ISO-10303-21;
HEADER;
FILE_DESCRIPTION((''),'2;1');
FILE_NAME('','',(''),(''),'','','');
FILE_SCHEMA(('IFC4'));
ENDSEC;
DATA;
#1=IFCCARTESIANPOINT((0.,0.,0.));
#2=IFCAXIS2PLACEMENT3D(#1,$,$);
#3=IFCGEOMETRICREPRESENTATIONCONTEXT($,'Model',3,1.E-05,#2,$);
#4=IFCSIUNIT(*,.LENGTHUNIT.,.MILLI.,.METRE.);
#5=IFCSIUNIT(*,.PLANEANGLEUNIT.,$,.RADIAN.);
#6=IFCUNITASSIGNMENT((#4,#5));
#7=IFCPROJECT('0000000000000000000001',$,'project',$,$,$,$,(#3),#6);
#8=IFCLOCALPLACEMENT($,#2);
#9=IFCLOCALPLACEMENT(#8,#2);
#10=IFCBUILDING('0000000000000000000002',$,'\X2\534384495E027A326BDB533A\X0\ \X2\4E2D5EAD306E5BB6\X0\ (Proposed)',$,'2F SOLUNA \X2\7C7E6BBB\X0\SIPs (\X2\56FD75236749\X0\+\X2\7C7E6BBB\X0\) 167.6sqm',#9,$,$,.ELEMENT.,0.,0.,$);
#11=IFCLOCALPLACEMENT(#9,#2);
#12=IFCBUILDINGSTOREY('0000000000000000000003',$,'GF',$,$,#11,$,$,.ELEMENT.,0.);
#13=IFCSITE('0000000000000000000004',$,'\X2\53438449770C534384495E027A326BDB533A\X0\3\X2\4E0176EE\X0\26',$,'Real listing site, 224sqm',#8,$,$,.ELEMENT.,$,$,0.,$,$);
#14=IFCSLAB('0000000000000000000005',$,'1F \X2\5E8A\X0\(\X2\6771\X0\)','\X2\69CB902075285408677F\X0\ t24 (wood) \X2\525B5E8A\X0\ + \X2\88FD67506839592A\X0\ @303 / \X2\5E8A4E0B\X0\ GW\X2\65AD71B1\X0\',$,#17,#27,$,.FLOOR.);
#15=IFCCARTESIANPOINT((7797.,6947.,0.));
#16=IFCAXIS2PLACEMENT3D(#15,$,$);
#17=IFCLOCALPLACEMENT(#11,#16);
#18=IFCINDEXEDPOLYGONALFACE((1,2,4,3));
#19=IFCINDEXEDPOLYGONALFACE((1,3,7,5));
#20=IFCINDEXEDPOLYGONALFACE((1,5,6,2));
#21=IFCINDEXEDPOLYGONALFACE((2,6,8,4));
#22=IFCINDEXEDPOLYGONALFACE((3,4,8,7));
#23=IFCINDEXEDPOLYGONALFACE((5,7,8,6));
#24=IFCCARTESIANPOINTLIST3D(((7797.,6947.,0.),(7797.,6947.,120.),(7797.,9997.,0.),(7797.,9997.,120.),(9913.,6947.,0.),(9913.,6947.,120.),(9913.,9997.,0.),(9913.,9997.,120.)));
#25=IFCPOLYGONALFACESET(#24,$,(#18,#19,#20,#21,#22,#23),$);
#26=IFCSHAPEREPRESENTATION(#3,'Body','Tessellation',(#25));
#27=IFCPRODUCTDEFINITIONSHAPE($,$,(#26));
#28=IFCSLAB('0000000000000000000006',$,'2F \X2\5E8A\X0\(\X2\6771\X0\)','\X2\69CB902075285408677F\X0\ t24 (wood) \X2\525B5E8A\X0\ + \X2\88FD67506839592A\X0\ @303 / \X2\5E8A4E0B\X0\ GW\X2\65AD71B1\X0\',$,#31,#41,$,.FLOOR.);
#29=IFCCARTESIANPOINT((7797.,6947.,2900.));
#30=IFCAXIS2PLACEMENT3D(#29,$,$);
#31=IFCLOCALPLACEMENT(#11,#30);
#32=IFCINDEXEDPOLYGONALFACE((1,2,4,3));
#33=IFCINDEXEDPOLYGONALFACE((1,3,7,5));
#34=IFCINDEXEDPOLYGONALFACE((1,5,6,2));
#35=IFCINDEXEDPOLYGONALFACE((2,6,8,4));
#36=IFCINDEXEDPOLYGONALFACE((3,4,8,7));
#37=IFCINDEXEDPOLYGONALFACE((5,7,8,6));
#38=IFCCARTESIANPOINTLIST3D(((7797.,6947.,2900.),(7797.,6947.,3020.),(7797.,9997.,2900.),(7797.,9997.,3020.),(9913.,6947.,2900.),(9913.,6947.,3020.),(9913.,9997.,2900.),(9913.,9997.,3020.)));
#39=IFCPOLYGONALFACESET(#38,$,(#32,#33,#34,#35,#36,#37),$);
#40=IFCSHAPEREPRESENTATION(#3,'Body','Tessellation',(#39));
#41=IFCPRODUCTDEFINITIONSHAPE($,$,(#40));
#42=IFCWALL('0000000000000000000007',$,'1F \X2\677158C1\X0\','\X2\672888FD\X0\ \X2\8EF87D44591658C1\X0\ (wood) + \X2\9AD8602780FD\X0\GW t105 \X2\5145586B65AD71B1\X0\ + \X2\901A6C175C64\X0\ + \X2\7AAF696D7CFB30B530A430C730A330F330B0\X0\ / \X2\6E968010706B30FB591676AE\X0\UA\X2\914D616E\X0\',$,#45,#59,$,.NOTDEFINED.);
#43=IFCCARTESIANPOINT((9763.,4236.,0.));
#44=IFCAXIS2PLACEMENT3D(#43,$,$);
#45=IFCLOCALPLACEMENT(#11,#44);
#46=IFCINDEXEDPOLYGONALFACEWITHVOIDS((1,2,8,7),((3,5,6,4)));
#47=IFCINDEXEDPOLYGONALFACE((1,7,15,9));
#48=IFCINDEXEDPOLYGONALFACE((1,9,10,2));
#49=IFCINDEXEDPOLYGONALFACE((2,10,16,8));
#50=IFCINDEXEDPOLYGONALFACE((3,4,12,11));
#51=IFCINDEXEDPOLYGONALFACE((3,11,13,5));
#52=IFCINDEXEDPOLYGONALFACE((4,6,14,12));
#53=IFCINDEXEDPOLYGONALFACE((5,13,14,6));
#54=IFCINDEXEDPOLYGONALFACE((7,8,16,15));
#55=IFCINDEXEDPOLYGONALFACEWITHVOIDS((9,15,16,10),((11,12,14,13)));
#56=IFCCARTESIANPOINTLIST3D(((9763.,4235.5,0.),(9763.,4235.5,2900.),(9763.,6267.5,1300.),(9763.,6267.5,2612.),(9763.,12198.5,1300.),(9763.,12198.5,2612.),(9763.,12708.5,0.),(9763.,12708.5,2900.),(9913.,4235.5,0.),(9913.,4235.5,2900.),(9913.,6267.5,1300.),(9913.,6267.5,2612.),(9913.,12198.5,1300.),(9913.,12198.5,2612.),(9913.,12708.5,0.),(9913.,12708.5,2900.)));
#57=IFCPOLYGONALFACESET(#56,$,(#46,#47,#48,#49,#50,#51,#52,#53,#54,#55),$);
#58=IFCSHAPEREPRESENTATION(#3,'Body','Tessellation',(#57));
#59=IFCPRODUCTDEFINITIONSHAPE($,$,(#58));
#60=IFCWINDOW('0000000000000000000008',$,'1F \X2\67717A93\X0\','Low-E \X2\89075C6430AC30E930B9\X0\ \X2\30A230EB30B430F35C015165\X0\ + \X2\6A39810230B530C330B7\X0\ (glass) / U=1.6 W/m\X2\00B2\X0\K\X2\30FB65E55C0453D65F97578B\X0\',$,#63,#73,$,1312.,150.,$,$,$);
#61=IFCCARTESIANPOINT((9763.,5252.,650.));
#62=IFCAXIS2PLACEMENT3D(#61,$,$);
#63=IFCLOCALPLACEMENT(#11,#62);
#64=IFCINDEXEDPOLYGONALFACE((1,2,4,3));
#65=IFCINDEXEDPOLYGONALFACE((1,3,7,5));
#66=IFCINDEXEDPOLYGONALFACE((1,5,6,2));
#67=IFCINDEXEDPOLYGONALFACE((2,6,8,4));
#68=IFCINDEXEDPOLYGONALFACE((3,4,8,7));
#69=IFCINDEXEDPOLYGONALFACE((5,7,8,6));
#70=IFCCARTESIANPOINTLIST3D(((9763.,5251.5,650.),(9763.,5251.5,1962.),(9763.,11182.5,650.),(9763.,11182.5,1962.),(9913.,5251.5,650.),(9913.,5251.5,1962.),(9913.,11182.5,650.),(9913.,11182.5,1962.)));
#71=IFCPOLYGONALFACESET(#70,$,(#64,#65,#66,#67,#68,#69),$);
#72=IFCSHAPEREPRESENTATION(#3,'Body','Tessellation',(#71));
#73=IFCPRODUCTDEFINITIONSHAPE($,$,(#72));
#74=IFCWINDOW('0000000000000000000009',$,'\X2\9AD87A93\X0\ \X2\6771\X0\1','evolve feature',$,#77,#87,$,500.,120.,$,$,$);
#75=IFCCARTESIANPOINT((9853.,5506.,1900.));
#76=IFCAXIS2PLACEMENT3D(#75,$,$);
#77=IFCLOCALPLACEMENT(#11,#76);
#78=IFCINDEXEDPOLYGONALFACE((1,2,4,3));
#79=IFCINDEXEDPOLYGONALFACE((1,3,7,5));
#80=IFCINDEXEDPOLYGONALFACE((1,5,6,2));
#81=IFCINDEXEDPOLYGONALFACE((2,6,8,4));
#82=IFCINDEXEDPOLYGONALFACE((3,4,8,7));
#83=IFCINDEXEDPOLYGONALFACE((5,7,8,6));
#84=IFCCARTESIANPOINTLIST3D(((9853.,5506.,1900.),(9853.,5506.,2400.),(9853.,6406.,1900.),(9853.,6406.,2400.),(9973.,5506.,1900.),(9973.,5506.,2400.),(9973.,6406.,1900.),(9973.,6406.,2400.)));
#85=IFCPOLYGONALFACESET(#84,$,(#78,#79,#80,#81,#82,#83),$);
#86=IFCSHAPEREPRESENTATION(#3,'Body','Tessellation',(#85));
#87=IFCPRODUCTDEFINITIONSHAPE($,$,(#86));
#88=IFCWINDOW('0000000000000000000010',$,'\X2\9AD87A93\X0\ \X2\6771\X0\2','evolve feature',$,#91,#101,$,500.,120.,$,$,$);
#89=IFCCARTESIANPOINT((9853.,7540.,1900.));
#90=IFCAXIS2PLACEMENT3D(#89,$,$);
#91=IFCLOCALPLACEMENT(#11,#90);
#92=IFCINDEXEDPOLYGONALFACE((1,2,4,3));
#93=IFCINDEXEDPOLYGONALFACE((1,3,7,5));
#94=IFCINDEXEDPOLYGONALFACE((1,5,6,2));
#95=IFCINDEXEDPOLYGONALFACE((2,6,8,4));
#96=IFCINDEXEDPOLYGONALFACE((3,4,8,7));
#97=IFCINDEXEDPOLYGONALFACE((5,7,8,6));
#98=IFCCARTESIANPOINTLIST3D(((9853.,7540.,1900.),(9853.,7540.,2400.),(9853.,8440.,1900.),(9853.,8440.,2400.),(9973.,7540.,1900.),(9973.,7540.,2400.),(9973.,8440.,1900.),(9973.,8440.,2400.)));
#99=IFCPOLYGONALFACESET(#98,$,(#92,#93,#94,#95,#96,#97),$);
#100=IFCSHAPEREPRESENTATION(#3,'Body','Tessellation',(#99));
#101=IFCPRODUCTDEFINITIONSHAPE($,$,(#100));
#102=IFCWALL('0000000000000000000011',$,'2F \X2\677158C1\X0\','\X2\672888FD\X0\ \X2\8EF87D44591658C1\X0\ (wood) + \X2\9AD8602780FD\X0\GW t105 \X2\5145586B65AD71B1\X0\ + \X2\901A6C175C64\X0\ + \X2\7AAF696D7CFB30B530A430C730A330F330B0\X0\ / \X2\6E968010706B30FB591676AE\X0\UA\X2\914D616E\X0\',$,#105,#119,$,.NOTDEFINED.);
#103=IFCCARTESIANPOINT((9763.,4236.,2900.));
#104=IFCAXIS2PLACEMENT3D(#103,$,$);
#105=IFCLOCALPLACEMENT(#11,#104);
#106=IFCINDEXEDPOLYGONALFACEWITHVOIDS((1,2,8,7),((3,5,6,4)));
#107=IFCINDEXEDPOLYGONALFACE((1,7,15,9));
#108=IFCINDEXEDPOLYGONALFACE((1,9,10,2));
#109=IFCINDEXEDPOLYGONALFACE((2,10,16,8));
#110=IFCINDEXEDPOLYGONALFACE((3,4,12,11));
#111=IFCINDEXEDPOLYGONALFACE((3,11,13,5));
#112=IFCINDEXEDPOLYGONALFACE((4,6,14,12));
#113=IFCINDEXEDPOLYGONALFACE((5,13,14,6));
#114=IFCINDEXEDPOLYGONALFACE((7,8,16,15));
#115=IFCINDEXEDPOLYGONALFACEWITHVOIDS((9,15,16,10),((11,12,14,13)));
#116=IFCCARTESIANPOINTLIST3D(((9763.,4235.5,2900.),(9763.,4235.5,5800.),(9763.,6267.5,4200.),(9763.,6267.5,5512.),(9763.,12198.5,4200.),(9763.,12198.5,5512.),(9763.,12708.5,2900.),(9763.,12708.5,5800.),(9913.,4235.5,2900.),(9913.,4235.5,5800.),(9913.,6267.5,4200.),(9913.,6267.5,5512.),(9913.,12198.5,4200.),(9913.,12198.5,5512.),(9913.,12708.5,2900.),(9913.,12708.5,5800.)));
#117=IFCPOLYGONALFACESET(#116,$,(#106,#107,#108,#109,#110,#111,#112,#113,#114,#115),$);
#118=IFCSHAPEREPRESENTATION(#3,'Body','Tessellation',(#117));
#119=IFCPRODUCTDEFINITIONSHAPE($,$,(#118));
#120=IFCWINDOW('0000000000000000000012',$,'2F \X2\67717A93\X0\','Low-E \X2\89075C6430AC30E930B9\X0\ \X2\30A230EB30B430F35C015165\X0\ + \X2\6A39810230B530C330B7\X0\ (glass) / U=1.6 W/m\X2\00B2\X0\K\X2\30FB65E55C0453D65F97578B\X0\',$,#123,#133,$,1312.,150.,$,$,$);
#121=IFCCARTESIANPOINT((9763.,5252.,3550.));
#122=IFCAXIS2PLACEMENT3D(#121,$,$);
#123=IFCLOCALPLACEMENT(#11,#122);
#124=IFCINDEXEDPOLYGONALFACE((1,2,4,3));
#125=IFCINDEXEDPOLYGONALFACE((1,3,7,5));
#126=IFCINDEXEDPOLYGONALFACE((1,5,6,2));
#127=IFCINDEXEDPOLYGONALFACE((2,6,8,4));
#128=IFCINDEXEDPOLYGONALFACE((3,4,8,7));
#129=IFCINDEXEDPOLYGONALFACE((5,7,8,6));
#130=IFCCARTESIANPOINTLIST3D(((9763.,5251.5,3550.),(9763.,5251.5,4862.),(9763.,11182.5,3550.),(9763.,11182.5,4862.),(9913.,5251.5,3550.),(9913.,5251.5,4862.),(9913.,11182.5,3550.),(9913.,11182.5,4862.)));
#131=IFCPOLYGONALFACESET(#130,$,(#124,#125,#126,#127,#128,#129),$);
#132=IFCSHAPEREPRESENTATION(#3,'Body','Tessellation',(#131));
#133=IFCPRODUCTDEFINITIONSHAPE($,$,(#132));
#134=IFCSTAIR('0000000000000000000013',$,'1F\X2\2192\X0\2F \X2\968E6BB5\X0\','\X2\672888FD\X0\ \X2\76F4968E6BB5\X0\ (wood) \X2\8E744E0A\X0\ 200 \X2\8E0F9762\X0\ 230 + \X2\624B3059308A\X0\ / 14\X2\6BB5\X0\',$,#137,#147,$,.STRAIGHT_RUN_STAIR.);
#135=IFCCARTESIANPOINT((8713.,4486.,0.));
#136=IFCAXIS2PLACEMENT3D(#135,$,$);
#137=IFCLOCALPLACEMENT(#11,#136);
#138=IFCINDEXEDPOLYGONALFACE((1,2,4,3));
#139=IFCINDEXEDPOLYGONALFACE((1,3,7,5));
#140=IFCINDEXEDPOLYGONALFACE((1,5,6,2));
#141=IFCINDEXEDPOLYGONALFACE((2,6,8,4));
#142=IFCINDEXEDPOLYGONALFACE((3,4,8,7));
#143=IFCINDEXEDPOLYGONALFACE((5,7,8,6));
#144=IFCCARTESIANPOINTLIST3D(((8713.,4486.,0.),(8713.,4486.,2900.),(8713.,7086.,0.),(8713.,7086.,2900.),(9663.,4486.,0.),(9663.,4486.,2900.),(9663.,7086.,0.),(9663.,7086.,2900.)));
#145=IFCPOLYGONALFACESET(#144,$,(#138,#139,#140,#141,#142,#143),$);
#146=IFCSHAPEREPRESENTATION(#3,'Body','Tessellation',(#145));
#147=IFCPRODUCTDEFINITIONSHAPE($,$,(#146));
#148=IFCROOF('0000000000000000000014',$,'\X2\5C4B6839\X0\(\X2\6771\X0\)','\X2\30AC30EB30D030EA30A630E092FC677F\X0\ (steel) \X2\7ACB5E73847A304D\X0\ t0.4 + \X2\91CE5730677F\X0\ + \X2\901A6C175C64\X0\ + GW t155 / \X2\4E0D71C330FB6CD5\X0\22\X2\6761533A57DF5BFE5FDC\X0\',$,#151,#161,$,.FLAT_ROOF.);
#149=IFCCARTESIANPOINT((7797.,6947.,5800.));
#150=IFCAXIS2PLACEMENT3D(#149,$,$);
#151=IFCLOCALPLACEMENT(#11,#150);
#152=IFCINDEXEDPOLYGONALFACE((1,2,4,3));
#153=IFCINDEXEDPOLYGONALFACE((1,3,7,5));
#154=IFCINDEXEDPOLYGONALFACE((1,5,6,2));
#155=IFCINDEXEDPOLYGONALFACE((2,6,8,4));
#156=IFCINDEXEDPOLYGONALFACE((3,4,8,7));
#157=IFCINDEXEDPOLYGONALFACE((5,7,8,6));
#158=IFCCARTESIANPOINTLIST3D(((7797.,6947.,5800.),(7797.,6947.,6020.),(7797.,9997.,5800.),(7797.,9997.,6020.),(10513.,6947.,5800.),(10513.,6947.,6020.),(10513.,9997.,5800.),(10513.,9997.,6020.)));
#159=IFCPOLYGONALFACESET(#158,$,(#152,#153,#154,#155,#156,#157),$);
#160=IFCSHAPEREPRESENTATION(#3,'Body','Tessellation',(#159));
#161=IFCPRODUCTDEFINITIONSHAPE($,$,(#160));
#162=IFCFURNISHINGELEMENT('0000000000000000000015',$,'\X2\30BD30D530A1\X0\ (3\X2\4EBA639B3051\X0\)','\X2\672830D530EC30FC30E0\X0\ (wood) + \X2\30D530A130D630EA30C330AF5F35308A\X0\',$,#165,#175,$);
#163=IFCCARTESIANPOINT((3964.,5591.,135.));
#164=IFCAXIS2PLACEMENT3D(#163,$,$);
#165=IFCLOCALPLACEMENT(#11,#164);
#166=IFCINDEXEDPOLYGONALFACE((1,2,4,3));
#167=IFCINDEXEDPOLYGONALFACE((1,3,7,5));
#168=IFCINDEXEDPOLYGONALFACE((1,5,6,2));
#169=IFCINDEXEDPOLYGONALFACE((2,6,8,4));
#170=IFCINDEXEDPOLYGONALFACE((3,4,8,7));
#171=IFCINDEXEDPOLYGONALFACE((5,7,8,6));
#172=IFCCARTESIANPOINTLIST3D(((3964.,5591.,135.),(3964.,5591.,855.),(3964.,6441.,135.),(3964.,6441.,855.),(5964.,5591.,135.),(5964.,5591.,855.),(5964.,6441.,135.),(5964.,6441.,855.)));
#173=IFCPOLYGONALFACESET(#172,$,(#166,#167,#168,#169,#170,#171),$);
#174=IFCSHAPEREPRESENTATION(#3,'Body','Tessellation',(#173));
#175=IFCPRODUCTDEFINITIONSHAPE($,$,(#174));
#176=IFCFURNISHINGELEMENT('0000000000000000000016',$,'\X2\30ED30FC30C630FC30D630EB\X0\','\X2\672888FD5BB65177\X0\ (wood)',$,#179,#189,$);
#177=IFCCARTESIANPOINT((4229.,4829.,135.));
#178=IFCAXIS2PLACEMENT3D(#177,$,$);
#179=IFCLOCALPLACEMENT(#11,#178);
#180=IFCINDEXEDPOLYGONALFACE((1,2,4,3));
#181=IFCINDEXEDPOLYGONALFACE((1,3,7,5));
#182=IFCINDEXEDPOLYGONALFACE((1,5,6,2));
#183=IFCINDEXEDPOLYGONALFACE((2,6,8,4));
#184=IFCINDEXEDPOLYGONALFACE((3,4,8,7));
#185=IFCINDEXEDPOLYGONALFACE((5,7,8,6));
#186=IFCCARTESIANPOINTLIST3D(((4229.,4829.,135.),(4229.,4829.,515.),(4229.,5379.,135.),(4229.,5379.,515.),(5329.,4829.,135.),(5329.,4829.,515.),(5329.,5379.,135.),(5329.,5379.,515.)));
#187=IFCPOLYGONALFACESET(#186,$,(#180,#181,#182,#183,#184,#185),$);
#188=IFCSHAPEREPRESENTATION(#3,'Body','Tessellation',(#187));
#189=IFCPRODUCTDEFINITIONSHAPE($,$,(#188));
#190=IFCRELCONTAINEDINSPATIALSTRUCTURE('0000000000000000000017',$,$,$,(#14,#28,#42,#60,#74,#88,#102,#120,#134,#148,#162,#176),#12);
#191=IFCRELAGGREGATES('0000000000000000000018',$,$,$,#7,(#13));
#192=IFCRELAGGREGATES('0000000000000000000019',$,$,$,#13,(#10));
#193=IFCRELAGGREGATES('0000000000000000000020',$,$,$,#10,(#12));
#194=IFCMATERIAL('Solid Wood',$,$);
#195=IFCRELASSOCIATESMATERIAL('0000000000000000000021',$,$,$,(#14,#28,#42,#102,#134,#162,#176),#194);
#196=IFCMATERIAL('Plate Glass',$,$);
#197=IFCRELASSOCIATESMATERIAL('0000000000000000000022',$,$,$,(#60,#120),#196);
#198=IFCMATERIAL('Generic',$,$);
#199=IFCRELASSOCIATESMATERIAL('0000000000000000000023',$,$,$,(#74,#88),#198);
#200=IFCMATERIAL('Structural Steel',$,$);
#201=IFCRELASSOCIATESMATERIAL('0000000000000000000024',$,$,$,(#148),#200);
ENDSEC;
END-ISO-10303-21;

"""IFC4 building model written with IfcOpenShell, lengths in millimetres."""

from ifc_helpers import new_model, si_unit, frame, frame_2d, origin, place, context, project, spatial, rectangle, extrude, material, element, fill, save


model = new_model("IFC4")

# Units and contexts
model_context = context("Model", 3, precision=1e-05, world=origin())
ifc_project = project(units=[si_unit("LENGTHUNIT", "METRE", prefix="MILLI"), si_unit("PLANEANGLEUNIT", "RADIAN")], contexts=[model_context])

# Site, building, storey
site_placement = place(None, origin())
site = spatial("IfcSite", under=ifc_project, at=site_placement, Name="千葉県千葉市稲毛区3丁目26", ObjectType="Real listing site, 224sqm", CompositionType="ELEMENT", RefElevation=0.0)
building_placement = place(site_placement, origin())
building = spatial("IfcBuilding", under=site, at=building_placement, Name="千葉市稲毛区 中庭の家 (Proposed)", ObjectType="2F SOLUNA 籾殻SIPs (国産杉+籾殻) 167.6sqm", CompositionType="ELEMENT", ElevationOfRefHeight=0.0, ElevationOfTerrain=0.0)
storey_placement = place(building_placement, origin())
storey = spatial("IfcBuildingStorey", under=building, at=storey_placement, Name="GF", CompositionType="ELEMENT", Elevation=0.0)

# Slabs
ifc_material_1 = material(Name="Solid Wood")
slab_1_placement = place(storey_placement, frame((7797.0, 6947.0, 0.0)))
element("IfcSlab", 1, at=slab_1_placement, inside=storey, material=ifc_material_1, Name="1F 床(東)", Description="構造用合板 t24 (wood) 剛床 + 製材根太 @303 / 床下 GW断熱", PredefinedType="FLOOR", context=model_context, shape_type="SweptSolid", body=[
    extrude(rectangle(XDim=2116.0, YDim=3050.0, at=frame_2d((1058.0, 1525.0))), frame((7797.0, 6947.0, 0.0)), (0.0, 0.0, 1.0), 120.0),
])
slab_2_placement = place(storey_placement, frame((7797.0, 6947.0, 2900.0)))
element("IfcSlab", 2, at=slab_2_placement, inside=storey, material=ifc_material_1, Name="2F 床(東)", Description="構造用合板 t24 (wood) 剛床 + 製材根太 @303 / 床下 GW断熱", PredefinedType="FLOOR", context=model_context, shape_type="SweptSolid", body=[
    extrude(rectangle(XDim=2116.0, YDim=3050.0, at=frame_2d((1058.0, 1525.0))), frame((7797.0, 6947.0, 2900.0)), (0.0, 0.0, 1.0), 120.0),
])

# Wall, openings, windows
wall_1_placement = place(storey_placement, frame((9763.0, 4236.0, 0.0)))
wall_1 = element("IfcWall", 3, at=wall_1_placement, inside=storey, material=ifc_material_1, Name="1F 東壁", Description="木製 軸組外壁 (wood) + 高性能GW t105 充填断熱 + 通気層 + 窯業系サイディング / 準耐火・外皮UA配慮", PredefinedType="NOTDEFINED", context=model_context, shape_type="SweptSolid", body=[
    extrude(rectangle(XDim=150.0, YDim=8473.0, at=frame_2d((75.0, 4236.0))), frame((9763.0, 4236.0, 0.0)), (0.0, 0.0, 1.0), 2900.0),
])
opening_1_placement = place(storey_placement, frame((9763.0, 5252.0, 650.0)))
opening_1 = element("IfcOpeningElement", 4, at=opening_1_placement, cuts=wall_1, PredefinedType="NOTDEFINED", context=model_context, shape_type="SweptSolid", body=[
    extrude(rectangle(XDim=150.0, YDim=5931.0, at=frame_2d((75.0, 2965.0))), frame((9763.0, 5252.0, 650.0)), (0.0, 0.0, 1.0), 1312.0),
])
opening_2_placement = place(storey_placement, frame((9853.0, 5506.0, 1900.0)))
opening_2 = element("IfcOpeningElement", 5, at=opening_2_placement, cuts=wall_1, PredefinedType="NOTDEFINED", context=model_context, shape_type="SweptSolid", body=[
    extrude(rectangle(XDim=120.0, YDim=900.0, at=frame_2d((60.0, 450.0))), frame((9853.0, 5506.0, 1900.0)), (0.0, 0.0, 1.0), 500.0),
])
opening_3_placement = place(storey_placement, frame((9853.0, 7540.0, 1900.0)))
opening_3 = element("IfcOpeningElement", 6, at=opening_3_placement, cuts=wall_1, PredefinedType="NOTDEFINED", context=model_context, shape_type="SweptSolid", body=[
    extrude(rectangle(XDim=120.0, YDim=900.0, at=frame_2d((60.0, 450.0))), frame((9853.0, 7540.0, 1900.0)), (0.0, 0.0, 1.0), 500.0),
])
ifc_material_2 = material(Name="Plate Glass")
window_1_placement = place(storey_placement, frame((9763.0, 5252.0, 650.0)))
window_1 = element("IfcWindow", 7, at=window_1_placement, inside=storey, material=ifc_material_2, Name="1F 東窓", Description="Low-E 複層ガラス アルゴン封入 + 樹脂サッシ (glass) / U=1.6 W/m²K・日射取得型", OverallHeight=1312.0, OverallWidth=150.0, context=model_context, shape_type="SweptSolid", body=[
    extrude(rectangle(XDim=150.0, YDim=5931.0, at=frame_2d((75.0, 2965.0))), frame((9763.0, 5252.0, 650.0)), (0.0, 0.0, 1.0), 1312.0),
])
fill(opening_1, window_1)
ifc_material_3 = material(Name="Generic")
window_2_placement = place(storey_placement, frame((9853.0, 5506.0, 1900.0)))
window_2 = element("IfcWindow", 8, at=window_2_placement, inside=storey, material=ifc_material_3, Name="高窓 東1", Description="evolve feature", OverallHeight=500.0, OverallWidth=120.0, context=model_context, shape_type="SweptSolid", body=[
    extrude(rectangle(XDim=120.0, YDim=900.0, at=frame_2d((60.0, 450.0))), frame((9853.0, 5506.0, 1900.0)), (0.0, 0.0, 1.0), 500.0),
])
fill(opening_2, window_2)
window_3_placement = place(storey_placement, frame((9853.0, 7540.0, 1900.0)))
window_3 = element("IfcWindow", 9, at=window_3_placement, inside=storey, material=ifc_material_3, Name="高窓 東2", Description="evolve feature", OverallHeight=500.0, OverallWidth=120.0, context=model_context, shape_type="SweptSolid", body=[
    extrude(rectangle(XDim=120.0, YDim=900.0, at=frame_2d((60.0, 450.0))), frame((9853.0, 7540.0, 1900.0)), (0.0, 0.0, 1.0), 500.0),
])
fill(opening_3, window_3)

# Wall, opening, window
wall_2_placement = place(storey_placement, frame((9763.0, 4236.0, 2900.0)))
wall_2 = element("IfcWall", 10, at=wall_2_placement, inside=storey, material=ifc_material_1, Name="2F 東壁", Description="木製 軸組外壁 (wood) + 高性能GW t105 充填断熱 + 通気層 + 窯業系サイディング / 準耐火・外皮UA配慮", PredefinedType="NOTDEFINED", context=model_context, shape_type="SweptSolid", body=[
    extrude(rectangle(XDim=150.0, YDim=8473.0, at=frame_2d((75.0, 4236.0))), frame((9763.0, 4236.0, 2900.0)), (0.0, 0.0, 1.0), 2900.0),
])
opening_4_placement = place(storey_placement, frame((9763.0, 5252.0, 3550.0)))
opening_4 = element("IfcOpeningElement", 11, at=opening_4_placement, cuts=wall_2, PredefinedType="NOTDEFINED", context=model_context, shape_type="SweptSolid", body=[
    extrude(rectangle(XDim=150.0, YDim=5931.0, at=frame_2d((75.0, 2965.0))), frame((9763.0, 5252.0, 3550.0)), (0.0, 0.0, 1.0), 1312.0),
])
window_4_placement = place(storey_placement, frame((9763.0, 5252.0, 3550.0)))
window_4 = element("IfcWindow", 12, at=window_4_placement, inside=storey, material=ifc_material_2, Name="2F 東窓", Description="Low-E 複層ガラス アルゴン封入 + 樹脂サッシ (glass) / U=1.6 W/m²K・日射取得型", OverallHeight=1312.0, OverallWidth=150.0, context=model_context, shape_type="SweptSolid", body=[
    extrude(rectangle(XDim=150.0, YDim=5931.0, at=frame_2d((75.0, 2965.0))), frame((9763.0, 5252.0, 3550.0)), (0.0, 0.0, 1.0), 1312.0),
])
fill(opening_4, window_4)

# Stair
stair_placement = place(storey_placement, frame((8713.0, 4486.0, 0.0)))
element("IfcStair", 13, at=stair_placement, inside=storey, material=ifc_material_1, Name="1F→2F 階段", Description="木製 直階段 (wood) 蹴上 200 踏面 230 + 手すり / 14段", PredefinedType="STRAIGHT_RUN_STAIR", context=model_context, shape_type="SweptSolid", body=[
    extrude(rectangle(XDim=950.0, YDim=2600.0, at=frame_2d((475.0, 1300.0))), frame((8713.0, 4486.0, 0.0)), (0.0, 0.0, 1.0), 2900.0),
])

# Roof
ifc_material_4 = material(Name="Structural Steel")
roof_placement = place(storey_placement, frame((7797.0, 6947.0, 5800.0)))
element("IfcRoof", 14, at=roof_placement, inside=storey, material=ifc_material_4, Name="屋根(東)", Description="ガルバリウム鋼板 (steel) 立平葺き t0.4 + 野地板 + 通気層 + GW t155 / 不燃・法22条区域対応", PredefinedType="FLAT_ROOF", context=model_context, shape_type="SweptSolid", body=[
    extrude(rectangle(XDim=2716.0, YDim=3050.0, at=frame_2d((1358.0, 1525.0))), frame((7797.0, 6947.0, 5800.0)), (0.0, 0.0, 1.0), 220.0),
])

# Furnishing elements
furnishing_1_placement = place(storey_placement, frame((3964.0, 5591.0, 135.0)))
element("IfcFurnishingElement", 15, at=furnishing_1_placement, inside=storey, material=ifc_material_1, Name="ソファ (3人掛け)", Description="木フレーム (wood) + ファブリック張り", context=model_context, shape_type="SweptSolid", body=[
    extrude(rectangle(XDim=2000.0, YDim=850.0, at=frame_2d((1000.0, 425.0))), frame((3964.0, 5591.0, 135.0)), (0.0, 0.0, 1.0), 720.0),
])
furnishing_2_placement = place(storey_placement, frame((4229.0, 4829.0, 135.0)))
element("IfcFurnishingElement", 16, at=furnishing_2_placement, inside=storey, material=ifc_material_1, Name="ローテーブル", Description="木製家具 (wood)", context=model_context, shape_type="SweptSolid", body=[
    extrude(rectangle(XDim=1100.0, YDim=550.0, at=frame_2d((550.0, 275.0))), frame((4229.0, 4829.0, 135.0)), (0.0, 0.0, 1.0), 380.0),
])

save(model, "model.ifc")
